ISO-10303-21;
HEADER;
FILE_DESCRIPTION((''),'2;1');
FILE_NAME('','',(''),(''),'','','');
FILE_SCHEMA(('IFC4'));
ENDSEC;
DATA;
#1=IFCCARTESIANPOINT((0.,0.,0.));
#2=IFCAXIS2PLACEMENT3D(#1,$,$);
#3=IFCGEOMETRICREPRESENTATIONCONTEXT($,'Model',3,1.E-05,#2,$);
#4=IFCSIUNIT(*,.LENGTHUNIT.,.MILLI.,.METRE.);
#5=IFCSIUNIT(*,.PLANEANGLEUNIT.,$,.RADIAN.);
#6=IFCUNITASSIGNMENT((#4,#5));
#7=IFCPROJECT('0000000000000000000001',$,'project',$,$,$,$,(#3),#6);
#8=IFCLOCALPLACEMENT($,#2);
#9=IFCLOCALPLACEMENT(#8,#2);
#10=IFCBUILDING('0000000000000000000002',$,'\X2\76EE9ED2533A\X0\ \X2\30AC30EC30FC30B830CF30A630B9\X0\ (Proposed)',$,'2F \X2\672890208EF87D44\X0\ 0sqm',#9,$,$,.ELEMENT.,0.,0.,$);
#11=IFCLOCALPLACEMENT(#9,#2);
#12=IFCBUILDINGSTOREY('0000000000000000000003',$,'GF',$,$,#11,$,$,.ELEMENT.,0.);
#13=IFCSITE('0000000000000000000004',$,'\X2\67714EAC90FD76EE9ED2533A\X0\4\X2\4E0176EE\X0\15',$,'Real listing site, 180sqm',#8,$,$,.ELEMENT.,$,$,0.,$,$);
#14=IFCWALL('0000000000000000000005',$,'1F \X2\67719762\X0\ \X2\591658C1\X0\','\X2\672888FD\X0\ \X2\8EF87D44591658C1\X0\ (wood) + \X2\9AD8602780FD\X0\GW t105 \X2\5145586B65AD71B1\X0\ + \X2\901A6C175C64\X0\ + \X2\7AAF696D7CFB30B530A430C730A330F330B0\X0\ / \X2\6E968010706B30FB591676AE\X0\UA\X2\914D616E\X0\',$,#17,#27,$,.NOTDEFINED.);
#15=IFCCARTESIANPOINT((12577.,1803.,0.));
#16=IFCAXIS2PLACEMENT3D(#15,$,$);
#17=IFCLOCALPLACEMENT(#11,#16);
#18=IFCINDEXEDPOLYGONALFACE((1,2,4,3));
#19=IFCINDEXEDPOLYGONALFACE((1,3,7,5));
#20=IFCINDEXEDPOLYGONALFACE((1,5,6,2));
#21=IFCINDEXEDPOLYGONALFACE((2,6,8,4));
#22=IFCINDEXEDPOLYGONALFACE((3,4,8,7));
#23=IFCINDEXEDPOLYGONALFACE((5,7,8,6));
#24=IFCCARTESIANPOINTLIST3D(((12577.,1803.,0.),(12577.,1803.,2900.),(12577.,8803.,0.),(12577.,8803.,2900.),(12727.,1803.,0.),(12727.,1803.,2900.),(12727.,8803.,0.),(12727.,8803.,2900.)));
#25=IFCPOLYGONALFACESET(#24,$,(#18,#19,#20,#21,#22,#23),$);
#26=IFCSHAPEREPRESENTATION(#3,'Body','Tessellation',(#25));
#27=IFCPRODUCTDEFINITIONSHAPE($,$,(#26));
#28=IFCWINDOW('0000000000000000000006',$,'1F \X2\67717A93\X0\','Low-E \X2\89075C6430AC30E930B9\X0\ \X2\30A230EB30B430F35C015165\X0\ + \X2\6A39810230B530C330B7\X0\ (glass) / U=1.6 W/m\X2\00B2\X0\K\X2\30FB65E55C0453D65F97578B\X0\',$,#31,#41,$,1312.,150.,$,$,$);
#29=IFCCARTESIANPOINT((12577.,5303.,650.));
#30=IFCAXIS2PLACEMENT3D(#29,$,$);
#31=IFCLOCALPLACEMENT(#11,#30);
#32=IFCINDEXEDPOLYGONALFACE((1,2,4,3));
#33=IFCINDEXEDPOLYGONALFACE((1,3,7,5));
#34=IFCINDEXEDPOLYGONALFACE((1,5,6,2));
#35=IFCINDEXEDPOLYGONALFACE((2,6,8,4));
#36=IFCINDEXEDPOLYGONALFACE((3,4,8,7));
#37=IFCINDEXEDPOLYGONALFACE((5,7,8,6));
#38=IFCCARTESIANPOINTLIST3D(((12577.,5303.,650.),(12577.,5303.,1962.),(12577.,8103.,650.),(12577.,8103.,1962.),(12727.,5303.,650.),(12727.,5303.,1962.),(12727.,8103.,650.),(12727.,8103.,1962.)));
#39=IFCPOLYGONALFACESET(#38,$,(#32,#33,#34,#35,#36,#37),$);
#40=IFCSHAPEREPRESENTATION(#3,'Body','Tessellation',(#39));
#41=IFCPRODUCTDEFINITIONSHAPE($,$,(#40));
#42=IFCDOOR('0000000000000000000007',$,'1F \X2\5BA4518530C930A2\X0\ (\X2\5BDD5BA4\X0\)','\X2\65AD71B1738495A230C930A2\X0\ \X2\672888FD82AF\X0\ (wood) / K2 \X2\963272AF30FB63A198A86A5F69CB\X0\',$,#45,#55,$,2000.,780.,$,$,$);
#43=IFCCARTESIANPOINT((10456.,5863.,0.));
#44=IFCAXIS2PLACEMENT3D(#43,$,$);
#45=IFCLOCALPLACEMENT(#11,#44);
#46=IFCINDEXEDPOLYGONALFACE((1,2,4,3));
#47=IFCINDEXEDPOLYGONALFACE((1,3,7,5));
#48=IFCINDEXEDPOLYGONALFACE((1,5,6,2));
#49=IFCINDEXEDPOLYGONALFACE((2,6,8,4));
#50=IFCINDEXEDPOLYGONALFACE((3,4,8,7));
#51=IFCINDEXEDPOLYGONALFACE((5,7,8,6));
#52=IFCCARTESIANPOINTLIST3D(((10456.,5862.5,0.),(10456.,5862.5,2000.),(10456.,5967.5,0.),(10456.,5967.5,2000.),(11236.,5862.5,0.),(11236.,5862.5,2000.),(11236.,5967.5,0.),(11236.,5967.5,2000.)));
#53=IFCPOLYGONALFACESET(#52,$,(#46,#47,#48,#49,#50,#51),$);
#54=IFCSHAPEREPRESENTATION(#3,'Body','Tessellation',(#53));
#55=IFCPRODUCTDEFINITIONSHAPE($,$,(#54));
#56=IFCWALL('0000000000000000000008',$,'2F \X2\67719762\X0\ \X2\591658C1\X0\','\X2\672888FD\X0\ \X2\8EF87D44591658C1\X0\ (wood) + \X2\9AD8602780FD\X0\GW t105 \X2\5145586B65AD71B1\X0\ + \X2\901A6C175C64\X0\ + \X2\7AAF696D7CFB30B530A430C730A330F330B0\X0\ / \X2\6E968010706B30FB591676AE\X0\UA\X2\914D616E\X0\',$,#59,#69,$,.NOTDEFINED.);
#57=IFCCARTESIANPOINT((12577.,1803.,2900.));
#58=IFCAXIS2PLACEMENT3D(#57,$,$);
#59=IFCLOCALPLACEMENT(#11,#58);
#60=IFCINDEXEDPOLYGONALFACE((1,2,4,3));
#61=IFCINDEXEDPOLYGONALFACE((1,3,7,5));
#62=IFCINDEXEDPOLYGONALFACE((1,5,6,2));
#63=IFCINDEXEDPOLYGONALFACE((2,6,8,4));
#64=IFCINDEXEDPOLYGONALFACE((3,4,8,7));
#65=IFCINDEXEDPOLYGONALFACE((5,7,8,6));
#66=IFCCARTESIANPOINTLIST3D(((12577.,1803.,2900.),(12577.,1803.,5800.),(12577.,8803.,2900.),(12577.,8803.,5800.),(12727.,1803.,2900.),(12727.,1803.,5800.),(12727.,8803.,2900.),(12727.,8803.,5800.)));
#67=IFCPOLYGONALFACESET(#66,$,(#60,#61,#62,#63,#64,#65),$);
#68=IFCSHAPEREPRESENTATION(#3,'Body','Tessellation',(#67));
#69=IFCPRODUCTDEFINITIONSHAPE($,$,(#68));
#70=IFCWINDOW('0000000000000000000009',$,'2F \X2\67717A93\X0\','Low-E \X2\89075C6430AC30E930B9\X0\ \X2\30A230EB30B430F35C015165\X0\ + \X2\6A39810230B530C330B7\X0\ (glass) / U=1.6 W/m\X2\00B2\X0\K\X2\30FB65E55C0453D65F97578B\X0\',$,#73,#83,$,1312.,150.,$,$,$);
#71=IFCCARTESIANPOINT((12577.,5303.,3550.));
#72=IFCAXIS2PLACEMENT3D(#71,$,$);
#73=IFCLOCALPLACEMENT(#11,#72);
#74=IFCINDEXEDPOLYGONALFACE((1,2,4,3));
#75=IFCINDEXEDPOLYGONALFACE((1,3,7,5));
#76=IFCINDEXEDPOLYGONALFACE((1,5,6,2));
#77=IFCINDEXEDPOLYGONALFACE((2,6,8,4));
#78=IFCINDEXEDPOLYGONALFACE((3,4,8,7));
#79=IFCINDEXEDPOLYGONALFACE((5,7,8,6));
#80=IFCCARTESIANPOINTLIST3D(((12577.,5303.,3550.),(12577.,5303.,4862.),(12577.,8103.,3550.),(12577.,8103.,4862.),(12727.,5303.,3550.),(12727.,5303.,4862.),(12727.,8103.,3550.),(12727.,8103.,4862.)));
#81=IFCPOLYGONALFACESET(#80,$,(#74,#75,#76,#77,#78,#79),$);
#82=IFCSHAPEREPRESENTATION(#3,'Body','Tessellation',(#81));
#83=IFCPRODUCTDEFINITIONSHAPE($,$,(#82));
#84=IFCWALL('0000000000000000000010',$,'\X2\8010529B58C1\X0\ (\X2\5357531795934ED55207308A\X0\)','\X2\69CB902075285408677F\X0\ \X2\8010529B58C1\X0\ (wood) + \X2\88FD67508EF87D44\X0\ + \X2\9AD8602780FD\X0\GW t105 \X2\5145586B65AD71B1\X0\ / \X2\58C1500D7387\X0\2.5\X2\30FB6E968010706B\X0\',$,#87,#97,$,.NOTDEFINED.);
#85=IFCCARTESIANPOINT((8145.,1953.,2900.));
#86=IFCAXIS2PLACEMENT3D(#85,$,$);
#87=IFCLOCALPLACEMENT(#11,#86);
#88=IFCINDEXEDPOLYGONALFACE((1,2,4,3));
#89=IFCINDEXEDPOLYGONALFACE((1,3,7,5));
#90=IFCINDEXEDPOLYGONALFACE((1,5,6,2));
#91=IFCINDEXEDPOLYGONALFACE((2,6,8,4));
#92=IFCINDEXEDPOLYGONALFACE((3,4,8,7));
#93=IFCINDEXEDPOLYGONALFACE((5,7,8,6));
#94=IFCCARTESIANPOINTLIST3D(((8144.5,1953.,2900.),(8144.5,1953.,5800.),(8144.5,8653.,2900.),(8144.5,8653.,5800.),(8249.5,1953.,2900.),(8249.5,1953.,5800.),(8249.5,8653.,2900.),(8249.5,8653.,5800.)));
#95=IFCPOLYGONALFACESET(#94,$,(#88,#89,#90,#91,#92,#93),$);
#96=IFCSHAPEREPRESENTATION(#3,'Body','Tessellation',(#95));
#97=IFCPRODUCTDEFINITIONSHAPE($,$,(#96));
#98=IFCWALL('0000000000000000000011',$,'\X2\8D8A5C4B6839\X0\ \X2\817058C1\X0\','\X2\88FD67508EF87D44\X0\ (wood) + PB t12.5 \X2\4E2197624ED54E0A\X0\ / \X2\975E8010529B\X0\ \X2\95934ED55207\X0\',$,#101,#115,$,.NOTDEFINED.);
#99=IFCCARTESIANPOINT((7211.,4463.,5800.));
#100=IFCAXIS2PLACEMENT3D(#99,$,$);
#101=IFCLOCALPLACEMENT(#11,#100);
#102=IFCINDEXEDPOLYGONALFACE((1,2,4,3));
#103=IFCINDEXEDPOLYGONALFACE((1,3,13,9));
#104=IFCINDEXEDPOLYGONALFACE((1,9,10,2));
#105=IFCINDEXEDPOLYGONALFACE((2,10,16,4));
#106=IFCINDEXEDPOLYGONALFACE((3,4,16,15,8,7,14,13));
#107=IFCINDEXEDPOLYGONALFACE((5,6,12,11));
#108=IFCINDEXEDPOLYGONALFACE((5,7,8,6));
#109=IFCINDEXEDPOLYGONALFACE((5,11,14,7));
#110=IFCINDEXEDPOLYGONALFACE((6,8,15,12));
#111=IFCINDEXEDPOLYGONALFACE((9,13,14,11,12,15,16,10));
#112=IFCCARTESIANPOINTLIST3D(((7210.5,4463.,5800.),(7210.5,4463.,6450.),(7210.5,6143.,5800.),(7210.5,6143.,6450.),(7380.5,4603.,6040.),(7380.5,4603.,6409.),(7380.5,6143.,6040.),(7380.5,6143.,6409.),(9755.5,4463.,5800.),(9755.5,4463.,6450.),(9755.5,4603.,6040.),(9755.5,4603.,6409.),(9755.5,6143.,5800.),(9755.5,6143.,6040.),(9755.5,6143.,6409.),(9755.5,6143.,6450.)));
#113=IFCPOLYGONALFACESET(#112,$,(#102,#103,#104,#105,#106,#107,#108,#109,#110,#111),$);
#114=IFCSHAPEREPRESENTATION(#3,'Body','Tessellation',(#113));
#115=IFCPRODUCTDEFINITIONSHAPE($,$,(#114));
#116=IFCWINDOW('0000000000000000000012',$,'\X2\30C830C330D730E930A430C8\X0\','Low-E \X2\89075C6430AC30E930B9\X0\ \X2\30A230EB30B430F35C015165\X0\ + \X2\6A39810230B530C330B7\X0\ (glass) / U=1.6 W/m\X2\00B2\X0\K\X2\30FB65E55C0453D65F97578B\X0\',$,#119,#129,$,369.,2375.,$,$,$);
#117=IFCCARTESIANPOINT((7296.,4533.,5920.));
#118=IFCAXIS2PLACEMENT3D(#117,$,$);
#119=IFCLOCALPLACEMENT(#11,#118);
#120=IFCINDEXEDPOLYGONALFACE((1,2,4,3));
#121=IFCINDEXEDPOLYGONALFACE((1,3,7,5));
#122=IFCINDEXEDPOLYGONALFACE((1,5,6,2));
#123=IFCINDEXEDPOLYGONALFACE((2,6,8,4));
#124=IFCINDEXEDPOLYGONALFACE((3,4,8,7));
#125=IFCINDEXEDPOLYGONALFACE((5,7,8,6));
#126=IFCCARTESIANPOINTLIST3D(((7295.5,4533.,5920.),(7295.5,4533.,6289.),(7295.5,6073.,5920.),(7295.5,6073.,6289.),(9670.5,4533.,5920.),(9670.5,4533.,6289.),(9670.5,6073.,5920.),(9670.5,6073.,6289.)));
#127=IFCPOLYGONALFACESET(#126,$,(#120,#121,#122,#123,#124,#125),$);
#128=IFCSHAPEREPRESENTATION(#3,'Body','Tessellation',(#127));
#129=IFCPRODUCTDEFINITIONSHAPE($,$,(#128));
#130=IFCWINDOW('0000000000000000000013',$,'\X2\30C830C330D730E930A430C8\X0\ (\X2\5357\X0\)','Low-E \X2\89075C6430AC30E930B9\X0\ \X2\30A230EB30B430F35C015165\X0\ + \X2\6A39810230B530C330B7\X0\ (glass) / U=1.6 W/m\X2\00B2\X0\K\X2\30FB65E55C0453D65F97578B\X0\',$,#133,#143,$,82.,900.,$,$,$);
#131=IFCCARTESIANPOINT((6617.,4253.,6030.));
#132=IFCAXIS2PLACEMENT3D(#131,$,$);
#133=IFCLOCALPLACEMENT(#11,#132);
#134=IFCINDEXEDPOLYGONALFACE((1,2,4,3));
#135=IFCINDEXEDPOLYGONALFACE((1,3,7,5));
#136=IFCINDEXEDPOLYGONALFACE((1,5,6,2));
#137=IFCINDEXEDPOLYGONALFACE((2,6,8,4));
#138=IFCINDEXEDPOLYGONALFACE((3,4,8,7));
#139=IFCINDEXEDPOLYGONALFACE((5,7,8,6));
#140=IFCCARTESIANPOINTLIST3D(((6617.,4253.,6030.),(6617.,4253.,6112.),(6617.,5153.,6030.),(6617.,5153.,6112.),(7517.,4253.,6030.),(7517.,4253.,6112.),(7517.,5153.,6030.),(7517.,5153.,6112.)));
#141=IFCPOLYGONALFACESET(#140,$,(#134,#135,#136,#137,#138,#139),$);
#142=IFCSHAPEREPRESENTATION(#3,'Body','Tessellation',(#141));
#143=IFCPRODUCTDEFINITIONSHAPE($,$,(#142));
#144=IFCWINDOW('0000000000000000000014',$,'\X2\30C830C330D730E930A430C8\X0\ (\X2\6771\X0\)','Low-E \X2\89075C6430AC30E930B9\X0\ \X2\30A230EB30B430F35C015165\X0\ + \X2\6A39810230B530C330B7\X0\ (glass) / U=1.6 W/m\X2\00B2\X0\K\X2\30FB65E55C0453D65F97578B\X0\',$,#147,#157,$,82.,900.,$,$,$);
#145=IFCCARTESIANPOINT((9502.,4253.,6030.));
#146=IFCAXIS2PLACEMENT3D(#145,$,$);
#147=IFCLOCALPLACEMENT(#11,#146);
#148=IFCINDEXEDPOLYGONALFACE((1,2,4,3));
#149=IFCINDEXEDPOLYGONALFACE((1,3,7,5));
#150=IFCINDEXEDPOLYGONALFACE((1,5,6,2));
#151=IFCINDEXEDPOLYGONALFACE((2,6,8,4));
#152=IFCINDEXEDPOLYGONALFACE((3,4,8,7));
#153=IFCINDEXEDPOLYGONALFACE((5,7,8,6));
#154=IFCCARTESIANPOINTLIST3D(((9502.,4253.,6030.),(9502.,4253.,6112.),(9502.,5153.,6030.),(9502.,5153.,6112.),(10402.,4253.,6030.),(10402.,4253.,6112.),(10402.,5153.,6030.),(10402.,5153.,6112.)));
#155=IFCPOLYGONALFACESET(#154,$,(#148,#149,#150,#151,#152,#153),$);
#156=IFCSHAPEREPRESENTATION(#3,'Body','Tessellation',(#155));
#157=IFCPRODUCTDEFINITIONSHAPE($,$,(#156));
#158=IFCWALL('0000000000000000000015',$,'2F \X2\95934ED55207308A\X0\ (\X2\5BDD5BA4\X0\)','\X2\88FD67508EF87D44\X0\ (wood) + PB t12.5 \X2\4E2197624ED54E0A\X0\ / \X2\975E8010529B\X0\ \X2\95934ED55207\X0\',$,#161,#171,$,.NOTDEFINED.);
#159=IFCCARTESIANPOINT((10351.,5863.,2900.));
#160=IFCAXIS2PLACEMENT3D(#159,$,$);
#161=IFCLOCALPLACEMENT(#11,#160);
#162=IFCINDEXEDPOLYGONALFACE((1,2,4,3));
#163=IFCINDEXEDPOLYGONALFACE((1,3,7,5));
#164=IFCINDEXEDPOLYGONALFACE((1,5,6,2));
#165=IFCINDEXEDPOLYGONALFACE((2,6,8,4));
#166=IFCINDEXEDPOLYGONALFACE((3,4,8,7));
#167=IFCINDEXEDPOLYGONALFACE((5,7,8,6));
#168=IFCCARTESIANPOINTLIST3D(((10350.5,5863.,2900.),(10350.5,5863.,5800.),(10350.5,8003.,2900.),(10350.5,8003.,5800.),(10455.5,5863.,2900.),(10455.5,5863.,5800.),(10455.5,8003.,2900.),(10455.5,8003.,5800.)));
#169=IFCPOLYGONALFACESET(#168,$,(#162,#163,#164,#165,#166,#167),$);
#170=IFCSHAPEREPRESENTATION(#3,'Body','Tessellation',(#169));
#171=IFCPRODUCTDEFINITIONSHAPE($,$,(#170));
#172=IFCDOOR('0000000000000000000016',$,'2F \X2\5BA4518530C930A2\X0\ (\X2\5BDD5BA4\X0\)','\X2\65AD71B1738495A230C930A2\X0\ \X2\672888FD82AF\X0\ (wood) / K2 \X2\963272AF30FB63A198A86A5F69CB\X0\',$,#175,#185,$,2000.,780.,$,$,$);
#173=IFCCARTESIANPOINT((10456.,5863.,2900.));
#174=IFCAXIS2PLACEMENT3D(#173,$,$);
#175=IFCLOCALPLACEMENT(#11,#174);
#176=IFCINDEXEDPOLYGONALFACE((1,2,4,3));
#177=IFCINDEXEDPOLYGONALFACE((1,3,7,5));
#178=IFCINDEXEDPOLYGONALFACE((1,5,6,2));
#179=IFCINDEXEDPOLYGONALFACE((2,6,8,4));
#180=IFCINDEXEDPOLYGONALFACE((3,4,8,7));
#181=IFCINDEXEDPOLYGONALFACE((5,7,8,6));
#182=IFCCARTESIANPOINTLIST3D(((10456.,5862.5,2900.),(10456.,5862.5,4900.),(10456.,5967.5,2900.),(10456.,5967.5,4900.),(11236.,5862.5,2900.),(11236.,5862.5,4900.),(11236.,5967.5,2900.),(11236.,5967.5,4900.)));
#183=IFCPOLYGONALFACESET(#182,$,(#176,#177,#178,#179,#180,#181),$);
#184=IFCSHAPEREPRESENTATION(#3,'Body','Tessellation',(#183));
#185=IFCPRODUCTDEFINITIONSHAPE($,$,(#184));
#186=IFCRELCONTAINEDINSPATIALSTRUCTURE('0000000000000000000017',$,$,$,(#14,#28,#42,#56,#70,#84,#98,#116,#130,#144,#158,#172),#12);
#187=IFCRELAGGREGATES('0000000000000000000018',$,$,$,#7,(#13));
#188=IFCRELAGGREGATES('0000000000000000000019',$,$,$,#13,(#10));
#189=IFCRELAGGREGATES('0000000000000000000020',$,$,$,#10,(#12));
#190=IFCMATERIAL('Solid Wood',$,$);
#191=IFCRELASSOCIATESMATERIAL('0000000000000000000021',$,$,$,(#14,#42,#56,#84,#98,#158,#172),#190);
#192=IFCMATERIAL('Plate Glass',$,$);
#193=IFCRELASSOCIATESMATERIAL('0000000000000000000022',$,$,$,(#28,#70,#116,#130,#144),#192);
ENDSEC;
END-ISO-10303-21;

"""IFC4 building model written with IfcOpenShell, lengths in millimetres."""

from ifc_helpers import new_model, si_unit, frame, frame_2d, origin, place, context, project, spatial, rectangle, extrude, material, element, fill, save


model = new_model("IFC4")

# Units and contexts
model_context = context("Model", 3, precision=1e-05, world=origin())
ifc_project = project(units=[si_unit("LENGTHUNIT", "METRE", prefix="MILLI"), si_unit("PLANEANGLEUNIT", "RADIAN")], contexts=[model_context])

# Site, building, storey
site_placement = place(None, origin())
site = spatial("IfcSite", under=ifc_project, at=site_placement, Name="東京都目黒区4丁目15", ObjectType="Real listing site, 180sqm", CompositionType="ELEMENT", RefElevation=0.0)
building_placement = place(site_placement, origin())
building = spatial("IfcBuilding", under=site, at=building_placement, Name="目黒区 ガレージハウス (Proposed)", ObjectType="2F 木造軸組 0sqm", CompositionType="ELEMENT", ElevationOfRefHeight=0.0, ElevationOfTerrain=0.0)
storey_placement = place(building_placement, origin())
storey = spatial("IfcBuildingStorey", under=building, at=storey_placement, Name="GF", CompositionType="ELEMENT", Elevation=0.0)

# Wall, opening, window
ifc_material_1 = material(Name="Solid Wood")
wall_1_placement = place(storey_placement, frame((12577.0, 1803.0, 0.0)))
wall_1 = element("IfcWall", 1, at=wall_1_placement, inside=storey, material=ifc_material_1, Name="1F 東面 外壁", Description="木製 軸組外壁 (wood) + 高性能GW t105 充填断熱 + 通気層 + 窯業系サイディング / 準耐火・外皮UA配慮", PredefinedType="NOTDEFINED", context=model_context, shape_type="SweptSolid", body=[
    extrude(rectangle(XDim=150.0, YDim=7000.0, at=frame_2d((75.0, 3500.0))), frame((12577.0, 1803.0, 0.0)), (0.0, 0.0, 1.0), 2900.0),
])
opening_1_placement = place(storey_placement, frame((12577.0, 5303.0, 650.0)))
opening_1 = element("IfcOpeningElement", 2, at=opening_1_placement, cuts=wall_1, PredefinedType="NOTDEFINED", context=model_context, shape_type="SweptSolid", body=[
    extrude(rectangle(XDim=150.0, YDim=2800.0, at=frame_2d((75.0, 1400.0))), frame((12577.0, 5303.0, 650.0)), (0.0, 0.0, 1.0), 1312.0),
])
ifc_material_2 = material(Name="Plate Glass")
window_1_placement = place(storey_placement, frame((12577.0, 5303.0, 650.0)))
window_1 = element("IfcWindow", 3, at=window_1_placement, inside=storey, material=ifc_material_2, Name="1F 東窓", Description="Low-E 複層ガラス アルゴン封入 + 樹脂サッシ (glass) / U=1.6 W/m²K・日射取得型", OverallHeight=1312.0, OverallWidth=150.0, context=model_context, shape_type="SweptSolid", body=[
    extrude(rectangle(XDim=150.0, YDim=2800.0, at=frame_2d((75.0, 1400.0))), frame((12577.0, 5303.0, 650.0)), (0.0, 0.0, 1.0), 1312.0),
])
fill(opening_1, window_1)

# Door
door_1_placement = place(storey_placement, frame((10456.0, 5863.0, 0.0)))
element("IfcDoor", 4, at=door_1_placement, inside=storey, material=ifc_material_1, Name="1F 室内ドア (寝室)", Description="断熱玄関ドア 木製芯 (wood) / K2 防犯・採風機構", OverallHeight=2000.0, OverallWidth=780.0, context=model_context, shape_type="SweptSolid", body=[
    extrude(rectangle(XDim=780.0, YDim=105.0, at=frame_2d((390.0, 52.0))), frame((10456.0, 5863.0, 0.0)), (0.0, 0.0, 1.0), 2000.0),
])

# Wall, opening, window
wall_2_placement = place(storey_placement, frame((12577.0, 1803.0, 2900.0)))
wall_2 = element("IfcWall", 5, at=wall_2_placement, inside=storey, material=ifc_material_1, Name="2F 東面 外壁", Description="木製 軸組外壁 (wood) + 高性能GW t105 充填断熱 + 通気層 + 窯業系サイディング / 準耐火・外皮UA配慮", PredefinedType="NOTDEFINED", context=model_context, shape_type="SweptSolid", body=[
    extrude(rectangle(XDim=150.0, YDim=7000.0, at=frame_2d((75.0, 3500.0))), frame((12577.0, 1803.0, 2900.0)), (0.0, 0.0, 1.0), 2900.0),
])
opening_2_placement = place(storey_placement, frame((12577.0, 5303.0, 3550.0)))
opening_2 = element("IfcOpeningElement", 6, at=opening_2_placement, cuts=wall_2, PredefinedType="NOTDEFINED", context=model_context, shape_type="SweptSolid", body=[
    extrude(rectangle(XDim=150.0, YDim=2800.0, at=frame_2d((75.0, 1400.0))), frame((12577.0, 5303.0, 3550.0)), (0.0, 0.0, 1.0), 1312.0),
])
window_2_placement = place(storey_placement, frame((12577.0, 5303.0, 3550.0)))
window_2 = element("IfcWindow", 7, at=window_2_placement, inside=storey, material=ifc_material_2, Name="2F 東窓", Description="Low-E 複層ガラス アルゴン封入 + 樹脂サッシ (glass) / U=1.6 W/m²K・日射取得型", OverallHeight=1312.0, OverallWidth=150.0, context=model_context, shape_type="SweptSolid", body=[
    extrude(rectangle(XDim=150.0, YDim=2800.0, at=frame_2d((75.0, 1400.0))), frame((12577.0, 5303.0, 3550.0)), (0.0, 0.0, 1.0), 1312.0),
])
fill(opening_2, window_2)

# Wall
wall_3_placement = place(storey_placement, frame((8145.0, 1953.0, 2900.0)))
element("IfcWall", 8, at=wall_3_placement, inside=storey, material=ifc_material_1, Name="耐力壁 (南北間仕切り)", Description="構造用合板 耐力壁 (wood) + 製材軸組 + 高性能GW t105 充填断熱 / 壁倍率2.5・準耐火", PredefinedType="NOTDEFINED", context=model_context, shape_type="SweptSolid", body=[
    extrude(rectangle(XDim=105.0, YDim=6700.0, at=frame_2d((52.0, 3350.0))), frame((8145.0, 1953.0, 2900.0)), (0.0, 0.0, 1.0), 2900.0),
])

# Wall, openings, windows
wall_4_placement = place(storey_placement, frame((7211.0, 4463.0, 5800.0)))
wall_4 = element("IfcWall", 9, at=wall_4_placement, inside=storey, material=ifc_material_1, Name="越屋根 腰壁", Description="製材軸組 (wood) + PB t12.5 両面仕上 / 非耐力 間仕切", PredefinedType="NOTDEFINED", context=model_context, shape_type="SweptSolid", body=[
    extrude(rectangle(XDim=2545.0, YDim=1680.0, at=frame_2d((1272.0, 840.0))), frame((7211.0, 4463.0, 5800.0)), (0.0, 0.0, 1.0), 650.0),
])
opening_3_placement = place(storey_placement, frame((7296.0, 4533.0, 5920.0)))
opening_3 = element("IfcOpeningElement", 10, at=opening_3_placement, cuts=wall_4, PredefinedType="NOTDEFINED", context=model_context, shape_type="SweptSolid", body=[
    extrude(rectangle(XDim=2375.0, YDim=1540.0, at=frame_2d((1187.0, 770.0))), frame((7296.0, 4533.0, 5920.0)), (0.0, 0.0, 1.0), 369.0),
])
opening_4_placement = place(storey_placement, frame((6617.0, 4253.0, 6030.0)))
opening_4 = element("IfcOpeningElement", 11, at=opening_4_placement, cuts=wall_4, PredefinedType="NOTDEFINED", context=model_context, shape_type="SweptSolid", body=[
    extrude(rectangle(XDim=900.0, YDim=900.0, at=frame_2d((450.0, 450.0))), frame((6617.0, 4253.0, 6030.0)), (0.0, 0.0, 1.0), 82.0),
])
opening_5_placement = place(storey_placement, frame((9502.0, 4253.0, 6030.0)))
opening_5 = element("IfcOpeningElement", 12, at=opening_5_placement, cuts=wall_4, PredefinedType="NOTDEFINED", context=model_context, shape_type="SweptSolid", body=[
    extrude(rectangle(XDim=900.0, YDim=900.0, at=frame_2d((450.0, 450.0))), frame((9502.0, 4253.0, 6030.0)), (0.0, 0.0, 1.0), 82.0),
])
window_3_placement = place(storey_placement, frame((7296.0, 4533.0, 5920.0)))
window_3 = element("IfcWindow", 13, at=window_3_placement, inside=storey, material=ifc_material_2, Name="トップライト", Description="Low-E 複層ガラス アルゴン封入 + 樹脂サッシ (glass) / U=1.6 W/m²K・日射取得型", OverallHeight=369.0, OverallWidth=2375.0, context=model_context, shape_type="SweptSolid", body=[
    extrude(rectangle(XDim=2375.0, YDim=1540.0, at=frame_2d((1187.0, 770.0))), frame((7296.0, 4533.0, 5920.0)), (0.0, 0.0, 1.0), 369.0),
])
fill(opening_3, window_3)
window_4_placement = place(storey_placement, frame((6617.0, 4253.0, 6030.0)))
window_4 = element("IfcWindow", 14, at=window_4_placement, inside=storey, material=ifc_material_2, Name="トップライト (南)", Description="Low-E 複層ガラス アルゴン封入 + 樹脂サッシ (glass) / U=1.6 W/m²K・日射取得型", OverallHeight=82.0, OverallWidth=900.0, context=model_context, shape_type="SweptSolid", body=[
    extrude(rectangle(XDim=900.0, YDim=900.0, at=frame_2d((450.0, 450.0))), frame((6617.0, 4253.0, 6030.0)), (0.0, 0.0, 1.0), 82.0),
])
fill(opening_4, window_4)
window_5_placement = place(storey_placement, frame((9502.0, 4253.0, 6030.0)))
window_5 = element("IfcWindow", 15, at=window_5_placement, inside=storey, material=ifc_material_2, Name="トップライト (東)", Description="Low-E 複層ガラス アルゴン封入 + 樹脂サッシ (glass) / U=1.6 W/m²K・日射取得型", OverallHeight=82.0, OverallWidth=900.0, context=model_context, shape_type="SweptSolid", body=[
    extrude(rectangle(XDim=900.0, YDim=900.0, at=frame_2d((450.0, 450.0))), frame((9502.0, 4253.0, 6030.0)), (0.0, 0.0, 1.0), 82.0),
])
fill(opening_5, window_5)

# Wall
wall_5_placement = place(storey_placement, frame((10351.0, 5863.0, 2900.0)))
element("IfcWall", 16, at=wall_5_placement, inside=storey, material=ifc_material_1, Name="2F 間仕切り (寝室)", Description="製材軸組 (wood) + PB t12.5 両面仕上 / 非耐力 間仕切", PredefinedType="NOTDEFINED", context=model_context, shape_type="SweptSolid", body=[
    extrude(rectangle(XDim=105.0, YDim=2140.0, at=frame_2d((52.0, 1070.0))), frame((10351.0, 5863.0, 2900.0)), (0.0, 0.0, 1.0), 2900.0),
])

# Door
door_2_placement = place(storey_placement, frame((10456.0, 5863.0, 2900.0)))
element("IfcDoor", 17, at=door_2_placement, inside=storey, material=ifc_material_1, Name="2F 室内ドア (寝室)", Description="断熱玄関ドア 木製芯 (wood) / K2 防犯・採風機構", OverallHeight=2000.0, OverallWidth=780.0, context=model_context, shape_type="SweptSolid", body=[
    extrude(rectangle(XDim=780.0, YDim=105.0, at=frame_2d((390.0, 52.0))), frame((10456.0, 5863.0, 2900.0)), (0.0, 0.0, 1.0), 2000.0),
])

save(model, "model.ifc")
